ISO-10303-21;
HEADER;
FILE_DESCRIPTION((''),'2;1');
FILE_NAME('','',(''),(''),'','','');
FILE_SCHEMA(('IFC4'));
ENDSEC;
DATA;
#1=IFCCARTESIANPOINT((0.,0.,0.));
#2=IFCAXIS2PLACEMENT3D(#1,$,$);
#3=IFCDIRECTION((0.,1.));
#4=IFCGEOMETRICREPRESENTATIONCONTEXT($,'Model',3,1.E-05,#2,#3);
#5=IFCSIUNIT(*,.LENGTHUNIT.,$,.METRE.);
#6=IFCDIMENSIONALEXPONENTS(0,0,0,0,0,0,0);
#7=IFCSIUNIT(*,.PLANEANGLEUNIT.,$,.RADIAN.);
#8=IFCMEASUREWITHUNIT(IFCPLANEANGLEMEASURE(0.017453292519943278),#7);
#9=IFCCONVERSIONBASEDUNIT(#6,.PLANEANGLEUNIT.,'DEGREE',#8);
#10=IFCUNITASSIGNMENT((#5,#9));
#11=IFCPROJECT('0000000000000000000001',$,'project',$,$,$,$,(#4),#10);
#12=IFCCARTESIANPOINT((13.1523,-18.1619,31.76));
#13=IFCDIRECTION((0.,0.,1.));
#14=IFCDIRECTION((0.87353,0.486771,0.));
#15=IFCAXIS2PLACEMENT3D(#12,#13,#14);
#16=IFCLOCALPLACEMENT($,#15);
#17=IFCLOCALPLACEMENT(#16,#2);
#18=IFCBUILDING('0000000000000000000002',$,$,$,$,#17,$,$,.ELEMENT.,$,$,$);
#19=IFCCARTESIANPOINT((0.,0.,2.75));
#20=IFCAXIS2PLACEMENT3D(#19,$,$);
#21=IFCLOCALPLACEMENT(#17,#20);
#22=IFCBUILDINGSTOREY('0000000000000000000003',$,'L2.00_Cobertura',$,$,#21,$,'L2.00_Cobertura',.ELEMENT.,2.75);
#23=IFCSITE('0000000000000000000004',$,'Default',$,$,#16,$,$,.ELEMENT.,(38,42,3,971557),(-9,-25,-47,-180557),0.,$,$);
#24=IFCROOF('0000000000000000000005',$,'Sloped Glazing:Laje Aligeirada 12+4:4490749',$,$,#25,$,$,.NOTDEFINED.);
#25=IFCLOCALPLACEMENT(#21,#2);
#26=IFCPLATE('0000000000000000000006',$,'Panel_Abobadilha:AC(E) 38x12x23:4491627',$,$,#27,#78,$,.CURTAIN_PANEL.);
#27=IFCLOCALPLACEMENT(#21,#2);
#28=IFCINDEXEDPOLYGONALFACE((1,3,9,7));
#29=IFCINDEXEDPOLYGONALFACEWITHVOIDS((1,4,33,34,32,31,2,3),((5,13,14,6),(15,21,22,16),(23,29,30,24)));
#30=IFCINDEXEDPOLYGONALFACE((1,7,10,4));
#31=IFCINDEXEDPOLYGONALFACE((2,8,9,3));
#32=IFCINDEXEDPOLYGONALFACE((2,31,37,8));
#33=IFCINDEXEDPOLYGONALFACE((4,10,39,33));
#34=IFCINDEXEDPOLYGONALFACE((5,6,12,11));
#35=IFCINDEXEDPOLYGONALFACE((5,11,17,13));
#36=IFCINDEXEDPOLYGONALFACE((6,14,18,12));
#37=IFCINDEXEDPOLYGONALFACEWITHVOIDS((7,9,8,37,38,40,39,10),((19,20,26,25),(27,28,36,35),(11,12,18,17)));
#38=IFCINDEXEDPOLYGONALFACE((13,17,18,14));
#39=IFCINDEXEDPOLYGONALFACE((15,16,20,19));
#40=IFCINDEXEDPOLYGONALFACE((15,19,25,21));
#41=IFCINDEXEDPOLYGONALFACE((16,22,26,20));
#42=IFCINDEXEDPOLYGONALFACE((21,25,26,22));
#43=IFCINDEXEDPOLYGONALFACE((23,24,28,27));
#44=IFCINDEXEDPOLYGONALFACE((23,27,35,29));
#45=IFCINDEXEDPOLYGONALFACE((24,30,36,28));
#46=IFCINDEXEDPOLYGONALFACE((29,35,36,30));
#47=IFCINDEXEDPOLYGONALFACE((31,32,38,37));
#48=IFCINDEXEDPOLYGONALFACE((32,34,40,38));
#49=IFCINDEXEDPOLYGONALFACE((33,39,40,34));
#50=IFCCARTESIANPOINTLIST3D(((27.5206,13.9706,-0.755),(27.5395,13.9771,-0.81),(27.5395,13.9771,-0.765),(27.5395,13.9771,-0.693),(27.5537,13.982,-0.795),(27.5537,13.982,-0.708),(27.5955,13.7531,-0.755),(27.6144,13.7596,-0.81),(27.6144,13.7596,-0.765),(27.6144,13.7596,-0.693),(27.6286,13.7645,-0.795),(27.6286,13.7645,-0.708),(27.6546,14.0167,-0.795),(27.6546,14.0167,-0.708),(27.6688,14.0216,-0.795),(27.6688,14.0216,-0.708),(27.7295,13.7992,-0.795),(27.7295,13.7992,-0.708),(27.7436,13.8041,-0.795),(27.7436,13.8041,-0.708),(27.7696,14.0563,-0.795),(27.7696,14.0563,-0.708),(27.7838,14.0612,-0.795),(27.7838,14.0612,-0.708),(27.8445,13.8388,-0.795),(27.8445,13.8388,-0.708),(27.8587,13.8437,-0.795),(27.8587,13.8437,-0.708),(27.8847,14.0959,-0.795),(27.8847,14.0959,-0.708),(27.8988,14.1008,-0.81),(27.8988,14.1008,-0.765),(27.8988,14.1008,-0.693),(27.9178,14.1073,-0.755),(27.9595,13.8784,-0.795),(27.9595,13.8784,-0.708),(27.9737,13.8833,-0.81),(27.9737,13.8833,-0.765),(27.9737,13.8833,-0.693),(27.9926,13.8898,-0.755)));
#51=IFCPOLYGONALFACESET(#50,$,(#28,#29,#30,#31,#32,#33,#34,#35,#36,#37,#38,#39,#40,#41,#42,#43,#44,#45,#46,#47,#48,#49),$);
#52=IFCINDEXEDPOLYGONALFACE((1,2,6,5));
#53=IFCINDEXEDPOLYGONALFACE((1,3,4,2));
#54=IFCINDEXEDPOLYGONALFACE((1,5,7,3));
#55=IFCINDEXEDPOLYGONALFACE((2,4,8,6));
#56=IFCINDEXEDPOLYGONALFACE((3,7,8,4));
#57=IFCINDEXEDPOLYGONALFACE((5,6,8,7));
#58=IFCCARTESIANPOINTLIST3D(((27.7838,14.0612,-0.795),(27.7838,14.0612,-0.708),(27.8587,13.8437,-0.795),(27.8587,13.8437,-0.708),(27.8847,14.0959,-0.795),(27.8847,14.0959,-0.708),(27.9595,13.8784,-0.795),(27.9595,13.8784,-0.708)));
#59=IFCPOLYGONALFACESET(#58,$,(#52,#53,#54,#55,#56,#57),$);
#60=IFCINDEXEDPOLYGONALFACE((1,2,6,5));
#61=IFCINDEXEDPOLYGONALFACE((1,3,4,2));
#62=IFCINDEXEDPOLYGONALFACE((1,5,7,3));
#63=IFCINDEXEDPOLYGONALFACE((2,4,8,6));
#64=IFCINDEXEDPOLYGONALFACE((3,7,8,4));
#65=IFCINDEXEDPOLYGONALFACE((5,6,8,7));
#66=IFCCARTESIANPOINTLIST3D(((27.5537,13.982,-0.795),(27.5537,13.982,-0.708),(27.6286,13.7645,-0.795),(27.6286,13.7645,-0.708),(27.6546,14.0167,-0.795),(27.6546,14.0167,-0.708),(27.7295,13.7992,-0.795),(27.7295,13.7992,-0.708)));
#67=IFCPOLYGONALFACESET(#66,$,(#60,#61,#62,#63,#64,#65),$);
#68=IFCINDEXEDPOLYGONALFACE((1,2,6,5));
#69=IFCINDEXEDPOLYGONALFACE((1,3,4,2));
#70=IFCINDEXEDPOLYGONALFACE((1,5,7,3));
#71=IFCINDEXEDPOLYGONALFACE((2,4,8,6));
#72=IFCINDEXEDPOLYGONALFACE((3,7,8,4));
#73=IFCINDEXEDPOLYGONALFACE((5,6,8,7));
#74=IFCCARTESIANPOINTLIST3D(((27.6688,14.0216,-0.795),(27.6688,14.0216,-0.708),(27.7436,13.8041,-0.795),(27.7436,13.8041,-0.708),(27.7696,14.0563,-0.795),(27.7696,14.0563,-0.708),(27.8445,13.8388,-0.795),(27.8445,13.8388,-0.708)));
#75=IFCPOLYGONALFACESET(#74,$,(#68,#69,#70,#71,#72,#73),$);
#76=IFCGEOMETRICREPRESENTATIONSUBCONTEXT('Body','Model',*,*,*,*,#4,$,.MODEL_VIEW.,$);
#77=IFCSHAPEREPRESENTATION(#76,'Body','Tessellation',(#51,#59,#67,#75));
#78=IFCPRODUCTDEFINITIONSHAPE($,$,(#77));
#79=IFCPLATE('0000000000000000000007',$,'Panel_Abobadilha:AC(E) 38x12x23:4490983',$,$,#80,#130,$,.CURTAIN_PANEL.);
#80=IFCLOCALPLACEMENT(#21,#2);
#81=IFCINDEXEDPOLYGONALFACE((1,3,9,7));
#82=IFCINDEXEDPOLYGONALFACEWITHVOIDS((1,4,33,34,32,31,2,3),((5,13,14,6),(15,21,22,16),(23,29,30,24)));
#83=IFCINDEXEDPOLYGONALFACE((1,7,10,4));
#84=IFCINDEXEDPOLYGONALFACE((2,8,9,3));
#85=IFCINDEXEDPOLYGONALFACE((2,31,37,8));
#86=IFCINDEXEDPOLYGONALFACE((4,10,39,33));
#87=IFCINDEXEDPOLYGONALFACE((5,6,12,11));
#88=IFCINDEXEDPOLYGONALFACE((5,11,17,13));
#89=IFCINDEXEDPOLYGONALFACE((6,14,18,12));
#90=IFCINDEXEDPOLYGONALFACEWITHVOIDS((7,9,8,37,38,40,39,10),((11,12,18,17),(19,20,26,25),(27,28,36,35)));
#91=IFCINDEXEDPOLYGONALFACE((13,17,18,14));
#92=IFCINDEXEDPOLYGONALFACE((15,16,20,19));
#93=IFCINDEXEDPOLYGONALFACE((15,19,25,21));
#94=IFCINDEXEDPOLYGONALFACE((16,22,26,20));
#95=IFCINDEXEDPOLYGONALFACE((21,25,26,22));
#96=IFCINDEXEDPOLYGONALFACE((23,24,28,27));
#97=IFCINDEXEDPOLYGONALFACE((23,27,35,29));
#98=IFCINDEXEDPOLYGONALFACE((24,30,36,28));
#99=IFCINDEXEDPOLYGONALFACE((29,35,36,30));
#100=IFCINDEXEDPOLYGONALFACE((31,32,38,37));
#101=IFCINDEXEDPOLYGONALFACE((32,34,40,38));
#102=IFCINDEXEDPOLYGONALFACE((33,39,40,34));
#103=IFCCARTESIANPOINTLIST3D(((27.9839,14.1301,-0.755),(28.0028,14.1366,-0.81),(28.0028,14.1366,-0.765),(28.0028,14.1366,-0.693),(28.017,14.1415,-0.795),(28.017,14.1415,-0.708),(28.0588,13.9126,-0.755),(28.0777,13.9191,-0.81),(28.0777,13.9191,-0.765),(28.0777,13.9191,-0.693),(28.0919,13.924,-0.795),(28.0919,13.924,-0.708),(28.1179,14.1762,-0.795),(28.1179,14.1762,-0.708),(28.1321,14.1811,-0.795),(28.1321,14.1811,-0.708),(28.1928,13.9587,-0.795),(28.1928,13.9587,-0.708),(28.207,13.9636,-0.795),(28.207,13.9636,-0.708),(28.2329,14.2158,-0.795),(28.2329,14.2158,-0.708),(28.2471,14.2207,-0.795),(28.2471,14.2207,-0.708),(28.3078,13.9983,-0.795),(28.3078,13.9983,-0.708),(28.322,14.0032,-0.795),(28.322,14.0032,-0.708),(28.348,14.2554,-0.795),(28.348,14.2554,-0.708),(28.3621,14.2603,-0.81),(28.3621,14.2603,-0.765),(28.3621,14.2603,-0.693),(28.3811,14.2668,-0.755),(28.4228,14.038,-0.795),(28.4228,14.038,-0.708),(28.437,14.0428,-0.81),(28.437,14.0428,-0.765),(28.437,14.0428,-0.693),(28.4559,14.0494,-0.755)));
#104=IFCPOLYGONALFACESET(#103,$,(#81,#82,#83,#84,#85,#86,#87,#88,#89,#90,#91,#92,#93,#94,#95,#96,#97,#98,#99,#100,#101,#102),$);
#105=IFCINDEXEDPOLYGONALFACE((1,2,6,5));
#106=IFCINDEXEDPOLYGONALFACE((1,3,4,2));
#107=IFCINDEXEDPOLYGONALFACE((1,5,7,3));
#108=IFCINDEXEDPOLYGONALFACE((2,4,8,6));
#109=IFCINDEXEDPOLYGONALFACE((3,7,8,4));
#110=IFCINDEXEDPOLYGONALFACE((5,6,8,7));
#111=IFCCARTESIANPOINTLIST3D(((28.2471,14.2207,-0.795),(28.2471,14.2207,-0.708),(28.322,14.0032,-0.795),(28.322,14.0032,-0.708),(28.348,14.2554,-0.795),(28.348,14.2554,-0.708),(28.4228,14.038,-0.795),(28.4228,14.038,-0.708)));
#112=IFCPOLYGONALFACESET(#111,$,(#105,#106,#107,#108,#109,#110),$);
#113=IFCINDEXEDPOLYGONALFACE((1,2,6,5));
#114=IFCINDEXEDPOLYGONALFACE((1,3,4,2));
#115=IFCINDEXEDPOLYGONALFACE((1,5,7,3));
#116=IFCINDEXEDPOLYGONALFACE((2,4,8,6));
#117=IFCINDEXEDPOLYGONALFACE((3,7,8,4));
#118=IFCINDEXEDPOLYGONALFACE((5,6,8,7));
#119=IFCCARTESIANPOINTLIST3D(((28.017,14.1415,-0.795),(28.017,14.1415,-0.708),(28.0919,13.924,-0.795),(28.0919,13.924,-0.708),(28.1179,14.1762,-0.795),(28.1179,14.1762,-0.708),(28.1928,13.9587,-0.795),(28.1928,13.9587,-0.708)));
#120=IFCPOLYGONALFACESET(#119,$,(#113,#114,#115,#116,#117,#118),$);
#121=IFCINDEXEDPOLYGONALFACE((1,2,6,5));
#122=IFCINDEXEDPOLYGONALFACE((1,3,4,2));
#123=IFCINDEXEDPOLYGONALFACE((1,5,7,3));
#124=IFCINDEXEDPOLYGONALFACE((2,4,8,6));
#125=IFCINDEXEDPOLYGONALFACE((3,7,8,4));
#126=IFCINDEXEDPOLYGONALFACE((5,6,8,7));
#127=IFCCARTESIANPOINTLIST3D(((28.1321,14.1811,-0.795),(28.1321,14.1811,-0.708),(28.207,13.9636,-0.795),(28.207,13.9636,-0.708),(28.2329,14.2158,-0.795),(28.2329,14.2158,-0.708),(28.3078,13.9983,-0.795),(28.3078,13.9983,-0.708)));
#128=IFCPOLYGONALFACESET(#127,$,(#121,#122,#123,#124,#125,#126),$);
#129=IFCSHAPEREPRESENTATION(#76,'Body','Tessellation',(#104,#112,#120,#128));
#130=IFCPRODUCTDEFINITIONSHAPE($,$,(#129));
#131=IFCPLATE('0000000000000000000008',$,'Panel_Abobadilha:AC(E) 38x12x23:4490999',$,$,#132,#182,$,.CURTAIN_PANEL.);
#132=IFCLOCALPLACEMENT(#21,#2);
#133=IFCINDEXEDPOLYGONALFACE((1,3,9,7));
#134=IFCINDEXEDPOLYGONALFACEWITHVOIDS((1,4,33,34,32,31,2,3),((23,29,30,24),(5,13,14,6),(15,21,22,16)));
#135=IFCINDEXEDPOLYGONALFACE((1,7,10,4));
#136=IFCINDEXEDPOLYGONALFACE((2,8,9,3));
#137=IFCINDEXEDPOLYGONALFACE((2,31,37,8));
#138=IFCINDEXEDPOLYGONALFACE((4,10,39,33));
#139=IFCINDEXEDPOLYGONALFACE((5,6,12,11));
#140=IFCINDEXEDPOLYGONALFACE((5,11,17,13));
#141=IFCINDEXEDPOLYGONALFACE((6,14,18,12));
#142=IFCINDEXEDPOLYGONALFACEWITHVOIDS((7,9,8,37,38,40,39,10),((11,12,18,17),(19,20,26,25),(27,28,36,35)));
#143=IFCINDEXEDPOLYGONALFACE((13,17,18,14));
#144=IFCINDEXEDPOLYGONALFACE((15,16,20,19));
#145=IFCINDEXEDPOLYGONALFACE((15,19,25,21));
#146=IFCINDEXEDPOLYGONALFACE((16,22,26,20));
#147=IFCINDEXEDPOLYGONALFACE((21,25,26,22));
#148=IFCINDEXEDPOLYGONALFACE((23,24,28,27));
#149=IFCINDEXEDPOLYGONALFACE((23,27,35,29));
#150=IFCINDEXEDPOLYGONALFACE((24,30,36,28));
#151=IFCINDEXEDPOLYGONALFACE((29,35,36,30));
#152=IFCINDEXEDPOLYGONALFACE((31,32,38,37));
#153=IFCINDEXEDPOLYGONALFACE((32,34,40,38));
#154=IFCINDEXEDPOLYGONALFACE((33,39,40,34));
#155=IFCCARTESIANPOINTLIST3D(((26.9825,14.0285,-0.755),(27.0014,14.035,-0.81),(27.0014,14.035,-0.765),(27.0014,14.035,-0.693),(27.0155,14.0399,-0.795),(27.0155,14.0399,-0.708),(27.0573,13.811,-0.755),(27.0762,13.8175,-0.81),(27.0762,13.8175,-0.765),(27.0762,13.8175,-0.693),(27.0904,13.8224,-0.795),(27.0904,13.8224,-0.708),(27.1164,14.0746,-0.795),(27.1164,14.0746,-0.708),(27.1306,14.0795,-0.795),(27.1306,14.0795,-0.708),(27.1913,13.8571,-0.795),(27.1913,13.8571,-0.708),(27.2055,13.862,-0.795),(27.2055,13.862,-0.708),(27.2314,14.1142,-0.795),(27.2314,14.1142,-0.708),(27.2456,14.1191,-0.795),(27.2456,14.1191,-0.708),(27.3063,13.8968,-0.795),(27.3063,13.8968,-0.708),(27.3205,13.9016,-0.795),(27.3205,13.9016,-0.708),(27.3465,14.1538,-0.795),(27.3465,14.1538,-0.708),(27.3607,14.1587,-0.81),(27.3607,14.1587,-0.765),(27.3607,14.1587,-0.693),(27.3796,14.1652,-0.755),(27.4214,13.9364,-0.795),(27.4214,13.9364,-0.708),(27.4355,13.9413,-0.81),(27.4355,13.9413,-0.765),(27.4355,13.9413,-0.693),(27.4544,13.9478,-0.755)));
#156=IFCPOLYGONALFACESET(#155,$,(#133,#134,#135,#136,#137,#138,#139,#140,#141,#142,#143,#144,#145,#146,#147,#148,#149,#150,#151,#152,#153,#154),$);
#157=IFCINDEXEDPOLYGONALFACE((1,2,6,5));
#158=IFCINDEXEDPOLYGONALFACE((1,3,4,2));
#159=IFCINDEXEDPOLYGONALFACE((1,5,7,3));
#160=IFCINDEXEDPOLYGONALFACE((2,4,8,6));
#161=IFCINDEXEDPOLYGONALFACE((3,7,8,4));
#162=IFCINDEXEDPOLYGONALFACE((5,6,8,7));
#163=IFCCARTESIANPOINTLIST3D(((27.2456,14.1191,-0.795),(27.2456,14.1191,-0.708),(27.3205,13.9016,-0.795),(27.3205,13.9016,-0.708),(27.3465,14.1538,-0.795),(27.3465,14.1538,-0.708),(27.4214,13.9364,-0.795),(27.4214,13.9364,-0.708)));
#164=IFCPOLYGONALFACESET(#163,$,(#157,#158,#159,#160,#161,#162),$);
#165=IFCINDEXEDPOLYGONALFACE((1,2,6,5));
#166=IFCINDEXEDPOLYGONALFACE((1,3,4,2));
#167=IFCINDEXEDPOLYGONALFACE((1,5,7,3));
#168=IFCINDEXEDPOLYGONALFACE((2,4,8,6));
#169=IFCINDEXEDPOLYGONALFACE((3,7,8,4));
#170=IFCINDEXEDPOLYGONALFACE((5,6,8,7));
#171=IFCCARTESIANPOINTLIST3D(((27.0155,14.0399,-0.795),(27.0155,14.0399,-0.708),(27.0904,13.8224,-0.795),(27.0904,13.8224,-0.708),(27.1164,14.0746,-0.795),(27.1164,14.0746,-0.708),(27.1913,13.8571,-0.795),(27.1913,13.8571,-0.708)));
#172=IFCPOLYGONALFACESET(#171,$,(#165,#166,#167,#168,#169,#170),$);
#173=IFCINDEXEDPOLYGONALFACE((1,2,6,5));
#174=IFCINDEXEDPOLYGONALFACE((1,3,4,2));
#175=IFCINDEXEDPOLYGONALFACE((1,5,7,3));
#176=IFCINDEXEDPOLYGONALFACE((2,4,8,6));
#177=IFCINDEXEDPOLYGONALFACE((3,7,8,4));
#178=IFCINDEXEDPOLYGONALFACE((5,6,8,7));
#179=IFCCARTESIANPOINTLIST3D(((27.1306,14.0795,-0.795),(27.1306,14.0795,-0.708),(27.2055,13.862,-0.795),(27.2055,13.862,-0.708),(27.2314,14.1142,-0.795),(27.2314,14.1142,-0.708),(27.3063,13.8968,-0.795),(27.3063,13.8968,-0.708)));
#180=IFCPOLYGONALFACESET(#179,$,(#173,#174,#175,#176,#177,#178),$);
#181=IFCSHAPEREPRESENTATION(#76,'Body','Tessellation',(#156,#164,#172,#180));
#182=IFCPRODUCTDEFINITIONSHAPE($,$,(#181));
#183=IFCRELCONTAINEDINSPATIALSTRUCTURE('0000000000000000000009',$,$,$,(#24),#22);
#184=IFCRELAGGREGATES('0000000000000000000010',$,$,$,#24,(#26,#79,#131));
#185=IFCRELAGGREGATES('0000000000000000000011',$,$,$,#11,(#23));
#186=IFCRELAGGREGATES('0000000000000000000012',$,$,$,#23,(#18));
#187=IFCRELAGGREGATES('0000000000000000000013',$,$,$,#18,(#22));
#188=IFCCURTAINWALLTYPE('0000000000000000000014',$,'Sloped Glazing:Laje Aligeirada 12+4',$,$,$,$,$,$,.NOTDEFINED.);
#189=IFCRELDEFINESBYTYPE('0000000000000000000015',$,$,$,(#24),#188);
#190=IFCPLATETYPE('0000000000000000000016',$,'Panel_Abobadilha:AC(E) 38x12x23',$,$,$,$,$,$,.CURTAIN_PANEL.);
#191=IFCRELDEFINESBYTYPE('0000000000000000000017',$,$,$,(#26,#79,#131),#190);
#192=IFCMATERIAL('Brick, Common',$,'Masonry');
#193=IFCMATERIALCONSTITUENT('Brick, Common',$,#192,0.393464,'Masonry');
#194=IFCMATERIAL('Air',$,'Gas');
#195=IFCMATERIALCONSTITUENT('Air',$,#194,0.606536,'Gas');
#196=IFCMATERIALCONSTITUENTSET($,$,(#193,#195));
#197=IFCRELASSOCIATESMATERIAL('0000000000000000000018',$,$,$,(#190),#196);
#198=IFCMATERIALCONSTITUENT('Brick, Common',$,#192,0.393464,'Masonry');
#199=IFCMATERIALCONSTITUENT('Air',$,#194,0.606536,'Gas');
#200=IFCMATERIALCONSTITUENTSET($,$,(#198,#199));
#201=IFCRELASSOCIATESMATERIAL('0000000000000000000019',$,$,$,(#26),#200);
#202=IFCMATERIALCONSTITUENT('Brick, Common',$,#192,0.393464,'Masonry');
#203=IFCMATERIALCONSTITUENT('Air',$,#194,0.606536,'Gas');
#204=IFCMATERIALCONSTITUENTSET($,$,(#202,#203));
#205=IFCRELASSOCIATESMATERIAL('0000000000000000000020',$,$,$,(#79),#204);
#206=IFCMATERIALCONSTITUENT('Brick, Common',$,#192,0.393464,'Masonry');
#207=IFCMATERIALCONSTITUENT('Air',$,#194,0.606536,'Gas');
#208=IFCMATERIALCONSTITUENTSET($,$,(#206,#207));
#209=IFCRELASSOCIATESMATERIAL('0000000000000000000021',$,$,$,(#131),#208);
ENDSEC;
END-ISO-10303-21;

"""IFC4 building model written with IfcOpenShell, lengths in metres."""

from ifc_helpers import new_model, entity, si_unit, converted_unit, direction, frame, origin, place, context, subcontext, project, spatial, indexed_curve, outline, extrude, source, transform, mapped, material, constituent, constituent_set, type_object, type_shapes, element, aggregate, save


model = new_model("IFC4")

# Units and contexts
model_context = context("Model", 3, precision=1e-05, world=origin(), true_north=direction((0.0, 1.0)))
body_context = subcontext(model_context, "Body", "Model", "MODEL_VIEW")
ifc_project = project(units=[si_unit("LENGTHUNIT", "METRE"), converted_unit("PLANEANGLEUNIT", "DEGREE", entity("IfcPlaneAngleMeasure", 0.017453292519943278), si_unit("PLANEANGLEUNIT", "RADIAN"), dimensions=[0, 0, 0, 0, 0, 0, 0])], contexts=[model_context])

# Site, building, storey
site_placement = place(None, frame((13.1523, -18.1619, 31.76), z_axis=(0.0, 0.0, 1.0), x_axis=(0.87353, 0.486771, 0.0)))
site = spatial("IfcSite", under=ifc_project, at=site_placement, Name="Default", CompositionType="ELEMENT", RefLatitude=(38, 42, 3, 971557), RefLongitude=(-9, -25, -47, -180557), RefElevation=0.0)
building_placement = place(site_placement, origin())
building = spatial("IfcBuilding", under=site, at=building_placement, CompositionType="ELEMENT")
storey_placement = place(building_placement, frame((0.0, 0.0, 2.75)))
storey = spatial("IfcBuildingStorey", under=building, at=storey_placement, Name="L2.00_Cobertura", LongName="L2.00_Cobertura", CompositionType="ELEMENT", Elevation=2.75)

# Roof, plates
curtain_wall_type = type_object("IfcCurtainWallType", Name="Sloped Glazing:Laje Aligeirada 12+4", PredefinedType="NOTDEFINED")
roof_placement = place(storey_placement, frame((0.0, 0.0, -2.75)))
roof = element("IfcRoof", 1, at=roof_placement, inside=storey, type_object=curtain_wall_type, Name="Sloped Glazing:Laje Aligeirada 12+4:4490749", PredefinedType="NOTDEFINED")
ifc_material_1 = material(Name="Brick, Common", Category="Masonry")
ifc_material_2 = material(Name="Air", Category="Gas")
ifc_constituent_1 = constituent(ifc_material_1, Name="Brick, Common", Category="Masonry", fraction=0.393464)
ifc_constituent_2 = constituent(ifc_material_2, Name="Air", Category="Gas", fraction=0.606536)
ifc_constituent_set_1 = constituent_set(constituents=[ifc_constituent_1, ifc_constituent_2])
plate_type = type_object("IfcPlateType", Name="Panel_Abobadilha:AC(E) 38x12x23", PredefinedType="CURTAIN_PANEL", material=ifc_constituent_set_1)
shared_shape_1 = source(origin(), body_context, "Body", "SweptSolid", [
    extrude(outline(indexed_curve([(-0.19, -0.0543), (0.19, -0.0543), (0.19, -0.0093), (0.21, 0.0007), (0.19, 0.0628), (-0.19, 0.0628), (-0.21, 0.0007), (-0.19, -0.0093), (-0.19, -0.0543)], self_intersect=False), holes=[indexed_curve([(-0.0683, 0.0477), (-0.0683, -0.0393), (-0.175, -0.0393), (-0.175, 0.0477), (-0.0683, 0.0477)], self_intersect=False), indexed_curve([(0.0533, 0.0477), (0.0533, -0.0393), (-0.0533, -0.0393), (-0.0533, 0.0477), (0.0533, 0.0477)], self_intersect=False), indexed_curve([(0.175, 0.0477), (0.175, -0.0393), (0.0683, -0.0393), (0.0683, 0.0477), (0.175, 0.0477)], self_intersect=False)]), frame((0.0, 0.0543, 0.0)), (0.0, 0.0, 1.0), 0.23),
    extrude(outline(indexed_curve([(-0.0533, -0.0435), (0.0533, -0.0435), (0.0533, 0.0435), (-0.0533, 0.0435), (-0.0533, -0.0435)], self_intersect=False)), frame((0.1217, 0.0585, 0.0), z_axis=(0.0, 0.0, 1.0), x_axis=(-1.0, 0.0, 0.0)), (0.0, 0.0, 1.0), 0.23),
    extrude(outline(indexed_curve([(-0.0533, -0.0435), (0.0533, -0.0435), (0.0533, 0.0435), (-0.0533, 0.0435), (-0.0533, -0.0435)], self_intersect=False)), frame((-0.1217, 0.0585, 0.0), z_axis=(0.0, 0.0, 1.0), x_axis=(-1.0, 0.0, 0.0)), (0.0, 0.0, 1.0), 0.23),
    extrude(outline(indexed_curve([(-0.0533, -0.0435), (0.0533, -0.0435), (0.0533, 0.0435), (-0.0533, 0.0435), (-0.0533, -0.0435)], self_intersect=False)), frame((0.0, 0.0585, 0.0), z_axis=(0.0, 0.0, 1.0), x_axis=(-1.0, 0.0, 0.0)), (0.0, 0.0, 1.0), 0.23),
])
type_shapes(plate_type, [shared_shape_1])
ifc_constituent_3 = constituent(ifc_material_1, Name="Brick, Common", Category="Masonry", fraction=0.393464)
ifc_constituent_4 = constituent(ifc_material_2, Name="Air", Category="Gas", fraction=0.606536)
ifc_constituent_set_2 = constituent_set(constituents=[ifc_constituent_3, ifc_constituent_4])
plate_1_placement = place(roof_placement, frame((27.7192, 14.0389, 1.94), z_axis=(0.325568, -0.945519, 0.0), x_axis=(0.945519, 0.325568, 0.0)))
plate_1 = element("IfcPlate", 2, at=plate_1_placement, type_object=plate_type, material=ifc_constituent_set_2, Name="Panel_Abobadilha:AC(E) 38x12x23:4491627", PredefinedType="CURTAIN_PANEL", context=body_context, shape_type="MappedRepresentation", body=[
    mapped(shared_shape_1, transform((0.0, 0.0, 0.0), scale=1.0)),
])
ifc_constituent_5 = constituent(ifc_material_1, Name="Brick, Common", Category="Masonry", fraction=0.393464)
ifc_constituent_6 = constituent(ifc_material_2, Name="Air", Category="Gas", fraction=0.606536)
ifc_constituent_set_3 = constituent_set(constituents=[ifc_constituent_5, ifc_constituent_6])
plate_2_placement = place(roof_placement, frame((28.1825, 14.1985, 1.94), z_axis=(0.325568, -0.945519, 0.0), x_axis=(0.945519, 0.325568, 0.0)))
plate_2 = element("IfcPlate", 3, at=plate_2_placement, type_object=plate_type, material=ifc_constituent_set_3, Name="Panel_Abobadilha:AC(E) 38x12x23:4490983", PredefinedType="CURTAIN_PANEL", context=body_context, shape_type="MappedRepresentation", body=[
    mapped(shared_shape_1, transform((0.0, 0.0, 0.0), scale=1.0)),
])
ifc_constituent_7 = constituent(ifc_material_1, Name="Brick, Common", Category="Masonry", fraction=0.393464)
ifc_constituent_8 = constituent(ifc_material_2, Name="Air", Category="Gas", fraction=0.606536)
ifc_constituent_set_4 = constituent_set(constituents=[ifc_constituent_7, ifc_constituent_8])
plate_3_placement = place(roof_placement, frame((27.181, 14.0969, 1.94), z_axis=(0.325568, -0.945519, 0.0), x_axis=(0.945519, 0.325568, 0.0)))
plate_3 = element("IfcPlate", 4, at=plate_3_placement, type_object=plate_type, material=ifc_constituent_set_4, Name="Panel_Abobadilha:AC(E) 38x12x23:4490999", PredefinedType="CURTAIN_PANEL", context=body_context, shape_type="MappedRepresentation", body=[
    mapped(shared_shape_1, transform((0.0, 0.0, 0.0), scale=1.0)),
])
aggregate(roof, [plate_1, plate_2, plate_3])

save(model, "model.ifc")
